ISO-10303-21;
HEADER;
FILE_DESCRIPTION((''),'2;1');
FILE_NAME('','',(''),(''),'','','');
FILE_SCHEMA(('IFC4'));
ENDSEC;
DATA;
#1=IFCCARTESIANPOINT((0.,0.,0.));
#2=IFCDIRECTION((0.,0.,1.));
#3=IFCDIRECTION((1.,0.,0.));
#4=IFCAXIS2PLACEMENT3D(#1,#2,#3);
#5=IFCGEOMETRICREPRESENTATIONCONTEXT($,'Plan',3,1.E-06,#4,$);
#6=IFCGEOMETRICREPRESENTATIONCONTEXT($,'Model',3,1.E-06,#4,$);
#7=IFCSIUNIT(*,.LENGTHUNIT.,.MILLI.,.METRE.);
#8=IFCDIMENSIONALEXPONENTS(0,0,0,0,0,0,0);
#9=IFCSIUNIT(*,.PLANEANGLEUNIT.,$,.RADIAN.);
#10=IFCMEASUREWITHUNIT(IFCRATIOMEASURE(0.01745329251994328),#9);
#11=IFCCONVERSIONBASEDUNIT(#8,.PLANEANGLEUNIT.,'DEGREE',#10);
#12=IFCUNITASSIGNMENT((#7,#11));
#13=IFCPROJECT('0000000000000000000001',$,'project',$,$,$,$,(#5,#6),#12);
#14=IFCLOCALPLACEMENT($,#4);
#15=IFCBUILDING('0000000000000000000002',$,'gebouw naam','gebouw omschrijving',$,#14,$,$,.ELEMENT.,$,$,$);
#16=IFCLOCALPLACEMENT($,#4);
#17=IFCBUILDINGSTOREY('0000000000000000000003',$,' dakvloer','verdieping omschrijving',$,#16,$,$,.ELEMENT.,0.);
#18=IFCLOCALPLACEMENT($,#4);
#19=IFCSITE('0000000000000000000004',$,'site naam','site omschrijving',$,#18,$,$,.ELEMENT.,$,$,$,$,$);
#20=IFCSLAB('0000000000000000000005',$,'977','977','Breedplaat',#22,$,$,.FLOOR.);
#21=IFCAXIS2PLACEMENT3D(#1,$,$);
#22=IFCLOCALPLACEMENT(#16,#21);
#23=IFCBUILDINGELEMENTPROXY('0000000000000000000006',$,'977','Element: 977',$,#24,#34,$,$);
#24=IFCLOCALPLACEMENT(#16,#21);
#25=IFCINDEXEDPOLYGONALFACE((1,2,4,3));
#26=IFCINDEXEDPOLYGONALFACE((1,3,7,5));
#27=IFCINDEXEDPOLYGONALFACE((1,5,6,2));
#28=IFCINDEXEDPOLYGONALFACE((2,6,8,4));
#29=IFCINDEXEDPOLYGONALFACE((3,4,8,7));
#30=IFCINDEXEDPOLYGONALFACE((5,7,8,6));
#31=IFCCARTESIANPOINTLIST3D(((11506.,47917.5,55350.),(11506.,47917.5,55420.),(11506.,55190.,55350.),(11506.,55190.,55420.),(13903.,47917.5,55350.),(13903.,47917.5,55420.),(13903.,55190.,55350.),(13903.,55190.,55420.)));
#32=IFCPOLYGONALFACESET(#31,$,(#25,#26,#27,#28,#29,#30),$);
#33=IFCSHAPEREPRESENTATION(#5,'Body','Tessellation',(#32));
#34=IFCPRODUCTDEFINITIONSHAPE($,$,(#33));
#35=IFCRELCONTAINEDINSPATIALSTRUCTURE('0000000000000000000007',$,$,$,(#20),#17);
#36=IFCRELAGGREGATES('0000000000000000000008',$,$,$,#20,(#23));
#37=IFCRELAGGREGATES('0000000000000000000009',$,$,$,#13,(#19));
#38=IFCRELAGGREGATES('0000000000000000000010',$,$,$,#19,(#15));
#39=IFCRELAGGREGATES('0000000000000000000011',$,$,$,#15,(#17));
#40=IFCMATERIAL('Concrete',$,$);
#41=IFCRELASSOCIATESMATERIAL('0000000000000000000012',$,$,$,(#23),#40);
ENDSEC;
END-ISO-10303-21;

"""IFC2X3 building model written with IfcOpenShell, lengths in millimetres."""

from ifc_helpers import new_model, entity, si_unit, converted_unit, frame, origin_with_axes, place, context, project, spatial, polyline, outline, extrude, material, element, aggregate, save


model = new_model("IFC2X3")

# Units and contexts
plan_context = context("Plan", 3, precision=1e-06, world=origin_with_axes())
model_context = context("Model", 3, precision=1e-06, world=origin_with_axes())
ifc_project = project(units=[si_unit("LENGTHUNIT", "METRE", prefix="MILLI"), converted_unit("PLANEANGLEUNIT", "DEGREE", entity("IfcRatioMeasure", 0.01745329251994328), si_unit("PLANEANGLEUNIT", "RADIAN"), dimensions=[0, 0, 0, 0, 0, 0, 0])], contexts=[plan_context, model_context])

# Site, building, storey
site_placement = place(None, origin_with_axes())
site = spatial("IfcSite", under=ifc_project, at=site_placement, Name="site naam", Description="site omschrijving", CompositionType="ELEMENT")
building_placement = place(None, origin_with_axes())
building = spatial("IfcBuilding", under=site, at=building_placement, Name="gebouw naam", Description="gebouw omschrijving", CompositionType="ELEMENT")
storey_placement = place(None, origin_with_axes())
storey = spatial("IfcBuildingStorey", under=building, at=storey_placement, Name=" dakvloer", Description="verdieping omschrijving", CompositionType="ELEMENT", Elevation=0.0)

# Slab, building element proxy, openings
slab_1_placement = place(None, frame((11506.0, 55190.0, 55350.0), z_axis=(0.0, 0.0, 1.0), x_axis=(0.0, -1.0, 0.0)))
slab_1 = element("IfcSlab", 1, at=slab_1_placement, inside=storey, Name="977", Description="977", ObjectType="Breedplaat", PredefinedType="FLOOR")
ifc_material_1 = material(Name="Concrete")
proxy_1_placement = place(slab_1_placement, origin_with_axes())
proxy_1 = element("IfcBuildingElementProxy", 2, at=proxy_1_placement, material=ifc_material_1, Name="977", Description="Element: 977", context=plan_context, shape_type="SweptSolid", body=[
    extrude(outline(polyline([(0.0, 2397.0), (0.0, 0.0), (7272.5, 0.0), (7272.5, 2397.0), (0.0, 2397.0)])), origin_with_axes(), (0.0, 0.0, 1.0), 70.0),
])
opening_1_placement = place(None, frame((11506.0, 55190.0, 55350.0), z_axis=(0.0, 0.0, 1.0), x_axis=(0.0, -1.0, 0.0)))
element("IfcOpeningElement", 3, at=opening_1_placement, cuts=proxy_1, ObjectType="Opening", context=plan_context, shape_type="SweptSolid", body=[
    extrude(outline(polyline([(-0.1, -0.1), (-0.1, 10.0), (10.0, -0.1), (-0.1, -0.1)])), frame((-1.2, -0.1, -0.1), z_axis=(1.0, 0.0, 0.0), x_axis=(0.0, 1.0, 0.0)), (0.0, 0.0, 1.0), 7274.7),
])
opening_2_placement = place(None, frame((11506.0, 55190.0, 55350.0), z_axis=(0.0, 0.0, 1.0), x_axis=(0.0, -1.0, 0.0)))
element("IfcOpeningElement", 4, at=opening_2_placement, cuts=proxy_1, ObjectType="Opening", context=plan_context, shape_type="SweptSolid", body=[
    extrude(outline(polyline([(-0.1, -0.1), (-0.1, 10.0), (10.0, -0.1), (-0.1, -0.1)])), frame((7273.7, 2397.2, -0.1), z_axis=(-1.0, 0.0, 0.0), x_axis=(0.0, -1.0, 0.0)), (0.0, 0.0, 1.0), 7274.7),
])
aggregate(slab_1, [proxy_1])

save(model, "model.ifc")
